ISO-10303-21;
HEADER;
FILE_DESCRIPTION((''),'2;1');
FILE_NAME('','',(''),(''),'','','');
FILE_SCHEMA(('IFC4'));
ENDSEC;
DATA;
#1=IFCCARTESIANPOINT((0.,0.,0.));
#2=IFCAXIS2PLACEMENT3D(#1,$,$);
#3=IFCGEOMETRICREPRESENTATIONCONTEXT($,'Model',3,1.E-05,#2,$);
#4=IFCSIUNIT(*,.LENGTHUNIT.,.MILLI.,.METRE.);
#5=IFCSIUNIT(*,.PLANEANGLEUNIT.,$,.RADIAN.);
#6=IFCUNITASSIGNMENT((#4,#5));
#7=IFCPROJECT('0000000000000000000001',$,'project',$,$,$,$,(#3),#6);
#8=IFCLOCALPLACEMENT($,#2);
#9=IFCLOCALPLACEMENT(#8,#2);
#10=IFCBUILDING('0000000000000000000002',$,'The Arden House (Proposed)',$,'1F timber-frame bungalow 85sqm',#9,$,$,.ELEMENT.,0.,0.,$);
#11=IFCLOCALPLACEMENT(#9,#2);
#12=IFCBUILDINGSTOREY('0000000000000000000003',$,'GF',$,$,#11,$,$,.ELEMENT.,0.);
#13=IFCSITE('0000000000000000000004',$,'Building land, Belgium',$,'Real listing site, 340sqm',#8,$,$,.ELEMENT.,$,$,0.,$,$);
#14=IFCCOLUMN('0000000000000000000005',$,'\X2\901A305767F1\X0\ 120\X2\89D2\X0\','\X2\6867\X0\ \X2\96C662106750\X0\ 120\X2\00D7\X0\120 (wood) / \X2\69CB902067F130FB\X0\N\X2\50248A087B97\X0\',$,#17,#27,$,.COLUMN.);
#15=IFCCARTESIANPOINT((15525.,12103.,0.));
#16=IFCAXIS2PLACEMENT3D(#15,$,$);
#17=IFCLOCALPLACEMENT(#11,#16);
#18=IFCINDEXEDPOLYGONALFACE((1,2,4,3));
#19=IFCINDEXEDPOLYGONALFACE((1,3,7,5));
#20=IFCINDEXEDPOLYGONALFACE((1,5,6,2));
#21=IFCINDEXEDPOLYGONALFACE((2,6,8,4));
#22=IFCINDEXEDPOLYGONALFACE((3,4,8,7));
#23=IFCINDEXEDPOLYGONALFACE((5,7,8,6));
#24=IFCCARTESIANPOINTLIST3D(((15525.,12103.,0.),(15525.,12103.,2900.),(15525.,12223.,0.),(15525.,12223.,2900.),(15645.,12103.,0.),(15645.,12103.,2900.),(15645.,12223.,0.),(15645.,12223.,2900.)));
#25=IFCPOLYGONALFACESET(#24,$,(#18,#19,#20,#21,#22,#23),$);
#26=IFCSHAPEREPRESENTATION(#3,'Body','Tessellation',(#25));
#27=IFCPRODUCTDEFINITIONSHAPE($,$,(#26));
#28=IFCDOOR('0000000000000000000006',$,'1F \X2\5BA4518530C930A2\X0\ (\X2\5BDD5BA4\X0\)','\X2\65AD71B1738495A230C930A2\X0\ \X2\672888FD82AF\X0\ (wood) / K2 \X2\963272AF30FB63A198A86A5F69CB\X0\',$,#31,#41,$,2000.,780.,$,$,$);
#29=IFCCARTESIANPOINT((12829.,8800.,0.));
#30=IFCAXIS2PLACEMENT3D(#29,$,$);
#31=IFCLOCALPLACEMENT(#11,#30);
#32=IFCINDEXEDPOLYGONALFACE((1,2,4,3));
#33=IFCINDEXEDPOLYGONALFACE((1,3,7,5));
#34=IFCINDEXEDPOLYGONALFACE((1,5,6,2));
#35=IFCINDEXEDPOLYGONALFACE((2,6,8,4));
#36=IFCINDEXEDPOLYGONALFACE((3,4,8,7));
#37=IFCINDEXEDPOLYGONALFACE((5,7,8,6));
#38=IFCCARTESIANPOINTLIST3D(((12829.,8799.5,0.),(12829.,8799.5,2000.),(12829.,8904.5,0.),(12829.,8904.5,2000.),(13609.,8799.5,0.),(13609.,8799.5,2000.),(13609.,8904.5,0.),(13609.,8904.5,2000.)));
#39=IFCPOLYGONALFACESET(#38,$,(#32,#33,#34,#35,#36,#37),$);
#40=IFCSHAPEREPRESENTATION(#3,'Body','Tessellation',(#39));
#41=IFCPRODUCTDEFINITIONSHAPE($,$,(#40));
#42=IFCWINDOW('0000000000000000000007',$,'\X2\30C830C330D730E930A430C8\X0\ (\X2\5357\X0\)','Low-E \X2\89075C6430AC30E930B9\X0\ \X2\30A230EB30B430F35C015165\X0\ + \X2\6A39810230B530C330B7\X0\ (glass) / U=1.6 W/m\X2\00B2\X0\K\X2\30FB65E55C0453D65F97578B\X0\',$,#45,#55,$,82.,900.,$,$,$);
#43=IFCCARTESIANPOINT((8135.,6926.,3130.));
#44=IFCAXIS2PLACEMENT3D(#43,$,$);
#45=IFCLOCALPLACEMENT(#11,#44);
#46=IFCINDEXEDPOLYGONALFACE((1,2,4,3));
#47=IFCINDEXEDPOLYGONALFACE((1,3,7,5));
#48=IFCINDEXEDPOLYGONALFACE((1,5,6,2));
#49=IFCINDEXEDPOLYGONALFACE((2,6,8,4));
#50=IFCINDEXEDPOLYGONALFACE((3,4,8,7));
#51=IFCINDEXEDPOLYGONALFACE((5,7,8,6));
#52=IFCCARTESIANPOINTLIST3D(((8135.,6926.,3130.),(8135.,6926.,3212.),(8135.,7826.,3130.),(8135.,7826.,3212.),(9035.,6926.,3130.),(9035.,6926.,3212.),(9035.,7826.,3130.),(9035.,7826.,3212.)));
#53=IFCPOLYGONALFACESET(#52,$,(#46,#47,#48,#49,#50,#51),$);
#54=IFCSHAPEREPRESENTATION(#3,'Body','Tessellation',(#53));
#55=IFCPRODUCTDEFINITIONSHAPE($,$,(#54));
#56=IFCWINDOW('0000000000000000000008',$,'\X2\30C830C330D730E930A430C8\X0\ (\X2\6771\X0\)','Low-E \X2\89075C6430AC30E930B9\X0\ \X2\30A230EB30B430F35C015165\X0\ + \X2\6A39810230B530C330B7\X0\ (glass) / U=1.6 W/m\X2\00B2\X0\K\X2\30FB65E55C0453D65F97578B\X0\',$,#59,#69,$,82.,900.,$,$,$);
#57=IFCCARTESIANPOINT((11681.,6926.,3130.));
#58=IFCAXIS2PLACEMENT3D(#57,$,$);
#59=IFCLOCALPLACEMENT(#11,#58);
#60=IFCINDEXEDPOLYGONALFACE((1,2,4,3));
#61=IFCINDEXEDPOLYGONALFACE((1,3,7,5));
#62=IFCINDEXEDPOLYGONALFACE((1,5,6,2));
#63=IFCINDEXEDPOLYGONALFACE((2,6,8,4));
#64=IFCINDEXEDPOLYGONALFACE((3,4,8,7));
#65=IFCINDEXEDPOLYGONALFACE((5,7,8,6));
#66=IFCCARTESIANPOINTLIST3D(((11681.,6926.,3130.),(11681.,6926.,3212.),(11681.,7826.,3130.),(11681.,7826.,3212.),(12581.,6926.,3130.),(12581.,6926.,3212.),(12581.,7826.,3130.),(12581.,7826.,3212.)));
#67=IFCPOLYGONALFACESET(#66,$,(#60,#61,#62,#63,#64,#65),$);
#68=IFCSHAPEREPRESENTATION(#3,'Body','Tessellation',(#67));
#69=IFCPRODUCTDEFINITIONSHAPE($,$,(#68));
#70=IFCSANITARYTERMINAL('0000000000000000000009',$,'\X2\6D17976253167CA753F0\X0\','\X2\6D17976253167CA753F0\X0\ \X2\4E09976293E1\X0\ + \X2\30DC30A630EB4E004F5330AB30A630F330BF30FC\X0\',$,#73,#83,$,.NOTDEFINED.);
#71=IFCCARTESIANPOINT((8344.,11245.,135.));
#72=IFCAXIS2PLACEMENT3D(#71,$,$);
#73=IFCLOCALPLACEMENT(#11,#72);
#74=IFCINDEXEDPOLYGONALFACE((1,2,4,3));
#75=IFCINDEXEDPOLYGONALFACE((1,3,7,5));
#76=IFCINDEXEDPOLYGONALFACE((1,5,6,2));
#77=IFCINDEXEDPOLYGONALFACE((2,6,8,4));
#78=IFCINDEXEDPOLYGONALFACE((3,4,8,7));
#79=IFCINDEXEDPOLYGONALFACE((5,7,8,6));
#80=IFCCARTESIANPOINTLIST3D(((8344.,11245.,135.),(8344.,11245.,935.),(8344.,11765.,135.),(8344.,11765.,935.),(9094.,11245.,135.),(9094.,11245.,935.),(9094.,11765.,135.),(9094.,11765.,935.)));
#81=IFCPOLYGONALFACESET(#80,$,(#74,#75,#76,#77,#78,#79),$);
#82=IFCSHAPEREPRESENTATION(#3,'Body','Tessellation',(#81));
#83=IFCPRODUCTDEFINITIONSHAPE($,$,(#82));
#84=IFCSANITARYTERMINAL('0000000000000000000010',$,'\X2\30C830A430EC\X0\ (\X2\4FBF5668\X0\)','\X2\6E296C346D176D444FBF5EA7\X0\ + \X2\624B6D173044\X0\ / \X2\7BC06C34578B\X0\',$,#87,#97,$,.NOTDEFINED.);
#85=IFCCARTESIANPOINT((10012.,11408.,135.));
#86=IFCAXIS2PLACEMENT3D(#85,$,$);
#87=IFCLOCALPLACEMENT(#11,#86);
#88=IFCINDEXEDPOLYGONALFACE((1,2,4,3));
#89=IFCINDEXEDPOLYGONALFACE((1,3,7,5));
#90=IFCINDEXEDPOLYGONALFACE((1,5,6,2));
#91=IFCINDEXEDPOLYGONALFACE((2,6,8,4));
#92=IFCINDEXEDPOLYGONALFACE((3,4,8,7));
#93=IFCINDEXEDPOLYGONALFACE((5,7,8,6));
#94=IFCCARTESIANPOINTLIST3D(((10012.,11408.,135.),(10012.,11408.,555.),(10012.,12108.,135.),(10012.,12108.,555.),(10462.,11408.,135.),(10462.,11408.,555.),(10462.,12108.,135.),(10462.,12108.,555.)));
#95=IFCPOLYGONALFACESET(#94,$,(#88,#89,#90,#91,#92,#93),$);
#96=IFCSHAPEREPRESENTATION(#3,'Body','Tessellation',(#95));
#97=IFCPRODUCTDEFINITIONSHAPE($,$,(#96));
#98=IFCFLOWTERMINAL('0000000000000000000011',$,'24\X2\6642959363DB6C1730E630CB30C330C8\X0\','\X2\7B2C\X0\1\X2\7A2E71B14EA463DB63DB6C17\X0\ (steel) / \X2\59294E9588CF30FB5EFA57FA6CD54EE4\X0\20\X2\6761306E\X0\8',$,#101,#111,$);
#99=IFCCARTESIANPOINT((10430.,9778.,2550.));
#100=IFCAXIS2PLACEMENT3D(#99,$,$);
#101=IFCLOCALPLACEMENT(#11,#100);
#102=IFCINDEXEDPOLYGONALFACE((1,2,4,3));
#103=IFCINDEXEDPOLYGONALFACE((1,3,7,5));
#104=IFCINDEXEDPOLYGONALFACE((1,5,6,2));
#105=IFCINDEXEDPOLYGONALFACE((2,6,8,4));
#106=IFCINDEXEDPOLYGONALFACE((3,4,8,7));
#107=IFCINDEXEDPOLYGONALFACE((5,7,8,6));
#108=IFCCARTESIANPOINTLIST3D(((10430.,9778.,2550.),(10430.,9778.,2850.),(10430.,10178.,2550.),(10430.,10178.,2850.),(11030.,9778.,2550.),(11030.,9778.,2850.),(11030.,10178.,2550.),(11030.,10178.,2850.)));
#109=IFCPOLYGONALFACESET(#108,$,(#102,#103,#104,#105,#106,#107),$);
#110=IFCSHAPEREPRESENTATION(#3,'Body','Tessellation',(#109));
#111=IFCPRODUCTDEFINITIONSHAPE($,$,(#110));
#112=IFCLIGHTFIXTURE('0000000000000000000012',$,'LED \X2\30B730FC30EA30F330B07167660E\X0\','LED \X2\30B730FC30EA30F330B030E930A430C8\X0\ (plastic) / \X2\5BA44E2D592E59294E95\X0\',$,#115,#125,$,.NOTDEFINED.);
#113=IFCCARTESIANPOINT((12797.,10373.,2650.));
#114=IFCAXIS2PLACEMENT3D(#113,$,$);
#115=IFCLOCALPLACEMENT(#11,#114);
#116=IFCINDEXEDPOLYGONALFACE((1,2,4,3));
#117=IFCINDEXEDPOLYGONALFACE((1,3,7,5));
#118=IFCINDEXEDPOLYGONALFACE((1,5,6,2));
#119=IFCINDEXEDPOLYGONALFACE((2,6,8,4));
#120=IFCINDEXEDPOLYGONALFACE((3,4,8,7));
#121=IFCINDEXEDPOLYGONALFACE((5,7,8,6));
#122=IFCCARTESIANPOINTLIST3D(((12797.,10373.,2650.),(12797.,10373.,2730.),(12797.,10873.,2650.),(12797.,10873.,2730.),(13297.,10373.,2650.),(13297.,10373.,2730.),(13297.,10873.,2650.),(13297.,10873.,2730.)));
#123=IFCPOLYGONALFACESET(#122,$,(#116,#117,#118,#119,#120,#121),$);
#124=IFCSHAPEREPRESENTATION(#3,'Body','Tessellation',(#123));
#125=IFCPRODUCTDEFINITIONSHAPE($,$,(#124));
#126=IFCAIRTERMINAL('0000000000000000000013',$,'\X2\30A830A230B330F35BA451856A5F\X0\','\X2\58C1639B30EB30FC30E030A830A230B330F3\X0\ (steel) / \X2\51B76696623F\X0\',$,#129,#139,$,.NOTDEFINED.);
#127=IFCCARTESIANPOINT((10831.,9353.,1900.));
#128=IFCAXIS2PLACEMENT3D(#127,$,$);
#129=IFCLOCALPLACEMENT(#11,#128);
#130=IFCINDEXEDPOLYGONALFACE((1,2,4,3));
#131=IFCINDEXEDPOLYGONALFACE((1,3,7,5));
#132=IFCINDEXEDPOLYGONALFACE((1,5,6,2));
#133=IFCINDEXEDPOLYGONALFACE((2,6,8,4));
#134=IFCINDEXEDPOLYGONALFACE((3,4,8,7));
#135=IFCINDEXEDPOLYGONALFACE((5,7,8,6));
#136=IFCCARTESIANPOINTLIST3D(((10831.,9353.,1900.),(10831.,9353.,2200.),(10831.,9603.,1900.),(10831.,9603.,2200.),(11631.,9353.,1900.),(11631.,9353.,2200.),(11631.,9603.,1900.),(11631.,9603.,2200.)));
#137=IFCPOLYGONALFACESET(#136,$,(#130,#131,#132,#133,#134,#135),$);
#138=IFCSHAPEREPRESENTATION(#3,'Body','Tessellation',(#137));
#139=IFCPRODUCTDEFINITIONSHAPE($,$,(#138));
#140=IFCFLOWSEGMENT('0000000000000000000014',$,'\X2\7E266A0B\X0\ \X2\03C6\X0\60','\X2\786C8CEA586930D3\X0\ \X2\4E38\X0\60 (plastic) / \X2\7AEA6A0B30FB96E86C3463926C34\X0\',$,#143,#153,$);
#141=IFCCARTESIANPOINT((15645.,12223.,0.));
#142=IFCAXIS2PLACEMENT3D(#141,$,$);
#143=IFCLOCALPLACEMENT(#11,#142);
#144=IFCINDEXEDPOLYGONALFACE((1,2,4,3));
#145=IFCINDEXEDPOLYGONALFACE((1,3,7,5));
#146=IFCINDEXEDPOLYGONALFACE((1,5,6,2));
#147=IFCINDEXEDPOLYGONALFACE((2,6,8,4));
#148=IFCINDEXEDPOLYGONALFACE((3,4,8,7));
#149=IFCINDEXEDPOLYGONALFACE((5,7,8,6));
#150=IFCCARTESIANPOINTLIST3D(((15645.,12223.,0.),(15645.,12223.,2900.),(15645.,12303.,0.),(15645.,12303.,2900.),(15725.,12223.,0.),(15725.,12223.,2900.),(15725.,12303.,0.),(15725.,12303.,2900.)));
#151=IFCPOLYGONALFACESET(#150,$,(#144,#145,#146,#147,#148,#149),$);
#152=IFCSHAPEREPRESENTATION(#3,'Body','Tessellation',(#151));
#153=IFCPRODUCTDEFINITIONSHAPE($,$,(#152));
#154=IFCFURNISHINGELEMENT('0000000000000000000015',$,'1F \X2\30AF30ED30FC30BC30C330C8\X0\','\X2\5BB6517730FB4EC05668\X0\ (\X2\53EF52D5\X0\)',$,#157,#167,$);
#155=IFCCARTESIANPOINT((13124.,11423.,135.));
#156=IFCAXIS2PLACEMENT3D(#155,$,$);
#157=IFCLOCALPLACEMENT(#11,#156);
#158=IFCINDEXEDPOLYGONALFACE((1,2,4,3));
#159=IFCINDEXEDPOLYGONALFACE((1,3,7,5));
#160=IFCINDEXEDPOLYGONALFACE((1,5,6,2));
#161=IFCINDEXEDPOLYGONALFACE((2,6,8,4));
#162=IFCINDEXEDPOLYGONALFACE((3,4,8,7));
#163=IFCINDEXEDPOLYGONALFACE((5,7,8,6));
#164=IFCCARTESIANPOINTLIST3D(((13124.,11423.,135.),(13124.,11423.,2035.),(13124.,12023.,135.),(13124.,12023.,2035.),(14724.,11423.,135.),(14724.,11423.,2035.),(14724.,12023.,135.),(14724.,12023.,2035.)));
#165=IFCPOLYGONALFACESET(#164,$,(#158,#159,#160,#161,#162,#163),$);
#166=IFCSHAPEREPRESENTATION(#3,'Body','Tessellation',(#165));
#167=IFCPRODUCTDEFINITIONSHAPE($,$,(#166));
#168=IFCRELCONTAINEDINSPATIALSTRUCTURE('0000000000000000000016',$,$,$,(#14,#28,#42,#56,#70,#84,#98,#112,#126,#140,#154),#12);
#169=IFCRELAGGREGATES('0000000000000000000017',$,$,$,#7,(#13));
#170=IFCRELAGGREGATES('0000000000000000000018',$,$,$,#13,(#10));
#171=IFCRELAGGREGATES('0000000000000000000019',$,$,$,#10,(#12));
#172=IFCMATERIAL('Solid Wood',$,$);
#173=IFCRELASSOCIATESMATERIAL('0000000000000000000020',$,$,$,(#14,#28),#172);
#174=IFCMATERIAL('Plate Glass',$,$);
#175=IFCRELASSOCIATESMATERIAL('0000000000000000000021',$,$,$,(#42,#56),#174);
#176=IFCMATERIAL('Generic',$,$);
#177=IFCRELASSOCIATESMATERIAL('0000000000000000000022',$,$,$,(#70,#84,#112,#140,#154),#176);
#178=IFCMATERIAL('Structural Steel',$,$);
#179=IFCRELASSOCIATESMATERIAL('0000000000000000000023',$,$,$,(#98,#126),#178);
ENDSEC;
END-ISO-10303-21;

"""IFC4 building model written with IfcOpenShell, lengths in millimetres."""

from ifc_helpers import new_model, si_unit, frame, frame_2d, origin, place, context, project, spatial, rectangle, extrude, material, element, save


model = new_model("IFC4")

# Units and contexts
model_context = context("Model", 3, precision=1e-05, world=origin())
ifc_project = project(units=[si_unit("LENGTHUNIT", "METRE", prefix="MILLI"), si_unit("PLANEANGLEUNIT", "RADIAN")], contexts=[model_context])

# Site, building, storey
site_placement = place(None, origin())
site = spatial("IfcSite", under=ifc_project, at=site_placement, Name="Building land, Belgium", ObjectType="Real listing site, 340sqm", CompositionType="ELEMENT", RefElevation=0.0)
building_placement = place(site_placement, origin())
building = spatial("IfcBuilding", under=site, at=building_placement, Name="The Arden House (Proposed)", ObjectType="1F timber-frame bungalow 85sqm", CompositionType="ELEMENT", ElevationOfRefHeight=0.0, ElevationOfTerrain=0.0)
storey_placement = place(building_placement, origin())
storey = spatial("IfcBuildingStorey", under=building, at=storey_placement, Name="GF", CompositionType="ELEMENT", Elevation=0.0)

# Column
ifc_material_1 = material(Name="Solid Wood")
column_1_placement = place(storey_placement, frame((15525.0, 12103.0, 0.0)))
element("IfcColumn", 1, at=column_1_placement, inside=storey, material=ifc_material_1, Name="通し柱 120角", Description="桧 集成材 120×120 (wood) / 構造柱・N値計算", PredefinedType="COLUMN", context=model_context, shape_type="SweptSolid", body=[
    extrude(rectangle(XDim=120.0, YDim=120.0, at=frame_2d((60.0, 60.0))), frame((15525.0, 12103.0, 0.0)), (0.0, 0.0, 1.0), 2900.0),
])

# Door
door_placement = place(storey_placement, frame((12829.0, 8800.0, 0.0)))
element("IfcDoor", 2, at=door_placement, inside=storey, material=ifc_material_1, Name="1F 室内ドア (寝室)", Description="断熱玄関ドア 木製芯 (wood) / K2 防犯・採風機構", OverallHeight=2000.0, OverallWidth=780.0, context=model_context, shape_type="SweptSolid", body=[
    extrude(rectangle(XDim=780.0, YDim=105.0, at=frame_2d((390.0, 52.0))), frame((12829.0, 8800.0, 0.0)), (0.0, 0.0, 1.0), 2000.0),
])

# Windows
ifc_material_2 = material(Name="Plate Glass")
window_1_placement = place(storey_placement, frame((8135.0, 6926.0, 3130.0)))
element("IfcWindow", 3, at=window_1_placement, inside=storey, material=ifc_material_2, Name="トップライト (南)", Description="Low-E 複層ガラス アルゴン封入 + 樹脂サッシ (glass) / U=1.6 W/m²K・日射取得型", OverallHeight=82.0, OverallWidth=900.0, context=model_context, shape_type="SweptSolid", body=[
    extrude(rectangle(XDim=900.0, YDim=900.0, at=frame_2d((450.0, 450.0))), frame((8135.0, 6926.0, 3130.0)), (0.0, 0.0, 1.0), 82.0),
])
window_2_placement = place(storey_placement, frame((11681.0, 6926.0, 3130.0)))
element("IfcWindow", 4, at=window_2_placement, inside=storey, material=ifc_material_2, Name="トップライト (東)", Description="Low-E 複層ガラス アルゴン封入 + 樹脂サッシ (glass) / U=1.6 W/m²K・日射取得型", OverallHeight=82.0, OverallWidth=900.0, context=model_context, shape_type="SweptSolid", body=[
    extrude(rectangle(XDim=900.0, YDim=900.0, at=frame_2d((450.0, 450.0))), frame((11681.0, 6926.0, 3130.0)), (0.0, 0.0, 1.0), 82.0),
])

# Sanitary terminals
ifc_material_3 = material(Name="Generic")
sanitary_terminal_1_placement = place(storey_placement, frame((8344.0, 11245.0, 135.0)))
element("IfcSanitaryTerminal", 5, at=sanitary_terminal_1_placement, inside=storey, material=ifc_material_3, Name="洗面化粧台", Description="洗面化粧台 三面鏡 + ボウル一体カウンター", PredefinedType="NOTDEFINED", context=model_context, shape_type="SweptSolid", body=[
    extrude(rectangle(XDim=750.0, YDim=520.0, at=frame_2d((375.0, 260.0))), frame((8344.0, 11245.0, 135.0)), (0.0, 0.0, 1.0), 800.0),
])
sanitary_terminal_2_placement = place(storey_placement, frame((10012.0, 11408.0, 135.0)))
element("IfcSanitaryTerminal", 6, at=sanitary_terminal_2_placement, inside=storey, material=ifc_material_3, Name="トイレ (便器)", Description="温水洗浄便座 + 手洗い / 節水型", PredefinedType="NOTDEFINED", context=model_context, shape_type="SweptSolid", body=[
    extrude(rectangle(XDim=450.0, YDim=700.0, at=frame_2d((225.0, 350.0))), frame((10012.0, 11408.0, 135.0)), (0.0, 0.0, 1.0), 420.0),
])

# Flow terminal
ifc_material_4 = material(Name="Structural Steel")
flow_terminal_placement = place(storey_placement, frame((10430.0, 9778.0, 2550.0)))
element("IfcFlowTerminal", 7, at=flow_terminal_placement, inside=storey, material=ifc_material_4, Name="24時間換気ユニット", Description="第1種熱交換換気 (steel) / 天井裏・建基法令20条の8", context=model_context, shape_type="SweptSolid", body=[
    extrude(rectangle(XDim=600.0, YDim=400.0, at=frame_2d((300.0, 200.0))), frame((10430.0, 9778.0, 2550.0)), (0.0, 0.0, 1.0), 300.0),
])

# Light fixture
light_fixture_placement = place(storey_placement, frame((12797.0, 10373.0, 2650.0)))
element("IfcLightFixture", 8, at=light_fixture_placement, inside=storey, material=ifc_material_3, Name="LED シーリング照明", Description="LED シーリングライト (plastic) / 室中央天井", PredefinedType="NOTDEFINED", context=model_context, shape_type="SweptSolid", body=[
    extrude(rectangle(XDim=500.0, YDim=500.0, at=frame_2d((250.0, 250.0))), frame((12797.0, 10373.0, 2650.0)), (0.0, 0.0, 1.0), 80.0),
])

# Air terminal
air_terminal_placement = place(storey_placement, frame((10831.0, 9353.0, 1900.0)))
element("IfcAirTerminal", 9, at=air_terminal_placement, inside=storey, material=ifc_material_4, Name="エアコン室内機", Description="壁掛ルームエアコン (steel) / 冷暖房", PredefinedType="NOTDEFINED", context=model_context, shape_type="SweptSolid", body=[
    extrude(rectangle(XDim=800.0, YDim=250.0, at=frame_2d((400.0, 125.0))), frame((10831.0, 9353.0, 1900.0)), (0.0, 0.0, 1.0), 300.0),
])

# Flow segment
flow_segment_placement = place(storey_placement, frame((15645.0, 12223.0, 0.0)))
element("IfcFlowSegment", 10, at=flow_segment_placement, inside=storey, material=ifc_material_3, Name="縦樋 φ60", Description="硬質塩ビ 丸60 (plastic) / 竪樋・雨水排水", context=model_context, shape_type="SweptSolid", body=[
    extrude(rectangle(XDim=80.0, YDim=80.0, at=frame_2d((40.0, 40.0))), frame((15645.0, 12223.0, 0.0)), (0.0, 0.0, 1.0), 2900.0),
])

# Furnishing element
furnishing_placement = place(storey_placement, frame((13124.0, 11423.0, 135.0)))
element("IfcFurnishingElement", 11, at=furnishing_placement, inside=storey, material=ifc_material_3, Name="1F クローゼット", Description="家具・什器 (可動)", context=model_context, shape_type="SweptSolid", body=[
    extrude(rectangle(XDim=1600.0, YDim=600.0, at=frame_2d((800.0, 300.0))), frame((13124.0, 11423.0, 135.0)), (0.0, 0.0, 1.0), 1900.0),
])

save(model, "model.ifc")
